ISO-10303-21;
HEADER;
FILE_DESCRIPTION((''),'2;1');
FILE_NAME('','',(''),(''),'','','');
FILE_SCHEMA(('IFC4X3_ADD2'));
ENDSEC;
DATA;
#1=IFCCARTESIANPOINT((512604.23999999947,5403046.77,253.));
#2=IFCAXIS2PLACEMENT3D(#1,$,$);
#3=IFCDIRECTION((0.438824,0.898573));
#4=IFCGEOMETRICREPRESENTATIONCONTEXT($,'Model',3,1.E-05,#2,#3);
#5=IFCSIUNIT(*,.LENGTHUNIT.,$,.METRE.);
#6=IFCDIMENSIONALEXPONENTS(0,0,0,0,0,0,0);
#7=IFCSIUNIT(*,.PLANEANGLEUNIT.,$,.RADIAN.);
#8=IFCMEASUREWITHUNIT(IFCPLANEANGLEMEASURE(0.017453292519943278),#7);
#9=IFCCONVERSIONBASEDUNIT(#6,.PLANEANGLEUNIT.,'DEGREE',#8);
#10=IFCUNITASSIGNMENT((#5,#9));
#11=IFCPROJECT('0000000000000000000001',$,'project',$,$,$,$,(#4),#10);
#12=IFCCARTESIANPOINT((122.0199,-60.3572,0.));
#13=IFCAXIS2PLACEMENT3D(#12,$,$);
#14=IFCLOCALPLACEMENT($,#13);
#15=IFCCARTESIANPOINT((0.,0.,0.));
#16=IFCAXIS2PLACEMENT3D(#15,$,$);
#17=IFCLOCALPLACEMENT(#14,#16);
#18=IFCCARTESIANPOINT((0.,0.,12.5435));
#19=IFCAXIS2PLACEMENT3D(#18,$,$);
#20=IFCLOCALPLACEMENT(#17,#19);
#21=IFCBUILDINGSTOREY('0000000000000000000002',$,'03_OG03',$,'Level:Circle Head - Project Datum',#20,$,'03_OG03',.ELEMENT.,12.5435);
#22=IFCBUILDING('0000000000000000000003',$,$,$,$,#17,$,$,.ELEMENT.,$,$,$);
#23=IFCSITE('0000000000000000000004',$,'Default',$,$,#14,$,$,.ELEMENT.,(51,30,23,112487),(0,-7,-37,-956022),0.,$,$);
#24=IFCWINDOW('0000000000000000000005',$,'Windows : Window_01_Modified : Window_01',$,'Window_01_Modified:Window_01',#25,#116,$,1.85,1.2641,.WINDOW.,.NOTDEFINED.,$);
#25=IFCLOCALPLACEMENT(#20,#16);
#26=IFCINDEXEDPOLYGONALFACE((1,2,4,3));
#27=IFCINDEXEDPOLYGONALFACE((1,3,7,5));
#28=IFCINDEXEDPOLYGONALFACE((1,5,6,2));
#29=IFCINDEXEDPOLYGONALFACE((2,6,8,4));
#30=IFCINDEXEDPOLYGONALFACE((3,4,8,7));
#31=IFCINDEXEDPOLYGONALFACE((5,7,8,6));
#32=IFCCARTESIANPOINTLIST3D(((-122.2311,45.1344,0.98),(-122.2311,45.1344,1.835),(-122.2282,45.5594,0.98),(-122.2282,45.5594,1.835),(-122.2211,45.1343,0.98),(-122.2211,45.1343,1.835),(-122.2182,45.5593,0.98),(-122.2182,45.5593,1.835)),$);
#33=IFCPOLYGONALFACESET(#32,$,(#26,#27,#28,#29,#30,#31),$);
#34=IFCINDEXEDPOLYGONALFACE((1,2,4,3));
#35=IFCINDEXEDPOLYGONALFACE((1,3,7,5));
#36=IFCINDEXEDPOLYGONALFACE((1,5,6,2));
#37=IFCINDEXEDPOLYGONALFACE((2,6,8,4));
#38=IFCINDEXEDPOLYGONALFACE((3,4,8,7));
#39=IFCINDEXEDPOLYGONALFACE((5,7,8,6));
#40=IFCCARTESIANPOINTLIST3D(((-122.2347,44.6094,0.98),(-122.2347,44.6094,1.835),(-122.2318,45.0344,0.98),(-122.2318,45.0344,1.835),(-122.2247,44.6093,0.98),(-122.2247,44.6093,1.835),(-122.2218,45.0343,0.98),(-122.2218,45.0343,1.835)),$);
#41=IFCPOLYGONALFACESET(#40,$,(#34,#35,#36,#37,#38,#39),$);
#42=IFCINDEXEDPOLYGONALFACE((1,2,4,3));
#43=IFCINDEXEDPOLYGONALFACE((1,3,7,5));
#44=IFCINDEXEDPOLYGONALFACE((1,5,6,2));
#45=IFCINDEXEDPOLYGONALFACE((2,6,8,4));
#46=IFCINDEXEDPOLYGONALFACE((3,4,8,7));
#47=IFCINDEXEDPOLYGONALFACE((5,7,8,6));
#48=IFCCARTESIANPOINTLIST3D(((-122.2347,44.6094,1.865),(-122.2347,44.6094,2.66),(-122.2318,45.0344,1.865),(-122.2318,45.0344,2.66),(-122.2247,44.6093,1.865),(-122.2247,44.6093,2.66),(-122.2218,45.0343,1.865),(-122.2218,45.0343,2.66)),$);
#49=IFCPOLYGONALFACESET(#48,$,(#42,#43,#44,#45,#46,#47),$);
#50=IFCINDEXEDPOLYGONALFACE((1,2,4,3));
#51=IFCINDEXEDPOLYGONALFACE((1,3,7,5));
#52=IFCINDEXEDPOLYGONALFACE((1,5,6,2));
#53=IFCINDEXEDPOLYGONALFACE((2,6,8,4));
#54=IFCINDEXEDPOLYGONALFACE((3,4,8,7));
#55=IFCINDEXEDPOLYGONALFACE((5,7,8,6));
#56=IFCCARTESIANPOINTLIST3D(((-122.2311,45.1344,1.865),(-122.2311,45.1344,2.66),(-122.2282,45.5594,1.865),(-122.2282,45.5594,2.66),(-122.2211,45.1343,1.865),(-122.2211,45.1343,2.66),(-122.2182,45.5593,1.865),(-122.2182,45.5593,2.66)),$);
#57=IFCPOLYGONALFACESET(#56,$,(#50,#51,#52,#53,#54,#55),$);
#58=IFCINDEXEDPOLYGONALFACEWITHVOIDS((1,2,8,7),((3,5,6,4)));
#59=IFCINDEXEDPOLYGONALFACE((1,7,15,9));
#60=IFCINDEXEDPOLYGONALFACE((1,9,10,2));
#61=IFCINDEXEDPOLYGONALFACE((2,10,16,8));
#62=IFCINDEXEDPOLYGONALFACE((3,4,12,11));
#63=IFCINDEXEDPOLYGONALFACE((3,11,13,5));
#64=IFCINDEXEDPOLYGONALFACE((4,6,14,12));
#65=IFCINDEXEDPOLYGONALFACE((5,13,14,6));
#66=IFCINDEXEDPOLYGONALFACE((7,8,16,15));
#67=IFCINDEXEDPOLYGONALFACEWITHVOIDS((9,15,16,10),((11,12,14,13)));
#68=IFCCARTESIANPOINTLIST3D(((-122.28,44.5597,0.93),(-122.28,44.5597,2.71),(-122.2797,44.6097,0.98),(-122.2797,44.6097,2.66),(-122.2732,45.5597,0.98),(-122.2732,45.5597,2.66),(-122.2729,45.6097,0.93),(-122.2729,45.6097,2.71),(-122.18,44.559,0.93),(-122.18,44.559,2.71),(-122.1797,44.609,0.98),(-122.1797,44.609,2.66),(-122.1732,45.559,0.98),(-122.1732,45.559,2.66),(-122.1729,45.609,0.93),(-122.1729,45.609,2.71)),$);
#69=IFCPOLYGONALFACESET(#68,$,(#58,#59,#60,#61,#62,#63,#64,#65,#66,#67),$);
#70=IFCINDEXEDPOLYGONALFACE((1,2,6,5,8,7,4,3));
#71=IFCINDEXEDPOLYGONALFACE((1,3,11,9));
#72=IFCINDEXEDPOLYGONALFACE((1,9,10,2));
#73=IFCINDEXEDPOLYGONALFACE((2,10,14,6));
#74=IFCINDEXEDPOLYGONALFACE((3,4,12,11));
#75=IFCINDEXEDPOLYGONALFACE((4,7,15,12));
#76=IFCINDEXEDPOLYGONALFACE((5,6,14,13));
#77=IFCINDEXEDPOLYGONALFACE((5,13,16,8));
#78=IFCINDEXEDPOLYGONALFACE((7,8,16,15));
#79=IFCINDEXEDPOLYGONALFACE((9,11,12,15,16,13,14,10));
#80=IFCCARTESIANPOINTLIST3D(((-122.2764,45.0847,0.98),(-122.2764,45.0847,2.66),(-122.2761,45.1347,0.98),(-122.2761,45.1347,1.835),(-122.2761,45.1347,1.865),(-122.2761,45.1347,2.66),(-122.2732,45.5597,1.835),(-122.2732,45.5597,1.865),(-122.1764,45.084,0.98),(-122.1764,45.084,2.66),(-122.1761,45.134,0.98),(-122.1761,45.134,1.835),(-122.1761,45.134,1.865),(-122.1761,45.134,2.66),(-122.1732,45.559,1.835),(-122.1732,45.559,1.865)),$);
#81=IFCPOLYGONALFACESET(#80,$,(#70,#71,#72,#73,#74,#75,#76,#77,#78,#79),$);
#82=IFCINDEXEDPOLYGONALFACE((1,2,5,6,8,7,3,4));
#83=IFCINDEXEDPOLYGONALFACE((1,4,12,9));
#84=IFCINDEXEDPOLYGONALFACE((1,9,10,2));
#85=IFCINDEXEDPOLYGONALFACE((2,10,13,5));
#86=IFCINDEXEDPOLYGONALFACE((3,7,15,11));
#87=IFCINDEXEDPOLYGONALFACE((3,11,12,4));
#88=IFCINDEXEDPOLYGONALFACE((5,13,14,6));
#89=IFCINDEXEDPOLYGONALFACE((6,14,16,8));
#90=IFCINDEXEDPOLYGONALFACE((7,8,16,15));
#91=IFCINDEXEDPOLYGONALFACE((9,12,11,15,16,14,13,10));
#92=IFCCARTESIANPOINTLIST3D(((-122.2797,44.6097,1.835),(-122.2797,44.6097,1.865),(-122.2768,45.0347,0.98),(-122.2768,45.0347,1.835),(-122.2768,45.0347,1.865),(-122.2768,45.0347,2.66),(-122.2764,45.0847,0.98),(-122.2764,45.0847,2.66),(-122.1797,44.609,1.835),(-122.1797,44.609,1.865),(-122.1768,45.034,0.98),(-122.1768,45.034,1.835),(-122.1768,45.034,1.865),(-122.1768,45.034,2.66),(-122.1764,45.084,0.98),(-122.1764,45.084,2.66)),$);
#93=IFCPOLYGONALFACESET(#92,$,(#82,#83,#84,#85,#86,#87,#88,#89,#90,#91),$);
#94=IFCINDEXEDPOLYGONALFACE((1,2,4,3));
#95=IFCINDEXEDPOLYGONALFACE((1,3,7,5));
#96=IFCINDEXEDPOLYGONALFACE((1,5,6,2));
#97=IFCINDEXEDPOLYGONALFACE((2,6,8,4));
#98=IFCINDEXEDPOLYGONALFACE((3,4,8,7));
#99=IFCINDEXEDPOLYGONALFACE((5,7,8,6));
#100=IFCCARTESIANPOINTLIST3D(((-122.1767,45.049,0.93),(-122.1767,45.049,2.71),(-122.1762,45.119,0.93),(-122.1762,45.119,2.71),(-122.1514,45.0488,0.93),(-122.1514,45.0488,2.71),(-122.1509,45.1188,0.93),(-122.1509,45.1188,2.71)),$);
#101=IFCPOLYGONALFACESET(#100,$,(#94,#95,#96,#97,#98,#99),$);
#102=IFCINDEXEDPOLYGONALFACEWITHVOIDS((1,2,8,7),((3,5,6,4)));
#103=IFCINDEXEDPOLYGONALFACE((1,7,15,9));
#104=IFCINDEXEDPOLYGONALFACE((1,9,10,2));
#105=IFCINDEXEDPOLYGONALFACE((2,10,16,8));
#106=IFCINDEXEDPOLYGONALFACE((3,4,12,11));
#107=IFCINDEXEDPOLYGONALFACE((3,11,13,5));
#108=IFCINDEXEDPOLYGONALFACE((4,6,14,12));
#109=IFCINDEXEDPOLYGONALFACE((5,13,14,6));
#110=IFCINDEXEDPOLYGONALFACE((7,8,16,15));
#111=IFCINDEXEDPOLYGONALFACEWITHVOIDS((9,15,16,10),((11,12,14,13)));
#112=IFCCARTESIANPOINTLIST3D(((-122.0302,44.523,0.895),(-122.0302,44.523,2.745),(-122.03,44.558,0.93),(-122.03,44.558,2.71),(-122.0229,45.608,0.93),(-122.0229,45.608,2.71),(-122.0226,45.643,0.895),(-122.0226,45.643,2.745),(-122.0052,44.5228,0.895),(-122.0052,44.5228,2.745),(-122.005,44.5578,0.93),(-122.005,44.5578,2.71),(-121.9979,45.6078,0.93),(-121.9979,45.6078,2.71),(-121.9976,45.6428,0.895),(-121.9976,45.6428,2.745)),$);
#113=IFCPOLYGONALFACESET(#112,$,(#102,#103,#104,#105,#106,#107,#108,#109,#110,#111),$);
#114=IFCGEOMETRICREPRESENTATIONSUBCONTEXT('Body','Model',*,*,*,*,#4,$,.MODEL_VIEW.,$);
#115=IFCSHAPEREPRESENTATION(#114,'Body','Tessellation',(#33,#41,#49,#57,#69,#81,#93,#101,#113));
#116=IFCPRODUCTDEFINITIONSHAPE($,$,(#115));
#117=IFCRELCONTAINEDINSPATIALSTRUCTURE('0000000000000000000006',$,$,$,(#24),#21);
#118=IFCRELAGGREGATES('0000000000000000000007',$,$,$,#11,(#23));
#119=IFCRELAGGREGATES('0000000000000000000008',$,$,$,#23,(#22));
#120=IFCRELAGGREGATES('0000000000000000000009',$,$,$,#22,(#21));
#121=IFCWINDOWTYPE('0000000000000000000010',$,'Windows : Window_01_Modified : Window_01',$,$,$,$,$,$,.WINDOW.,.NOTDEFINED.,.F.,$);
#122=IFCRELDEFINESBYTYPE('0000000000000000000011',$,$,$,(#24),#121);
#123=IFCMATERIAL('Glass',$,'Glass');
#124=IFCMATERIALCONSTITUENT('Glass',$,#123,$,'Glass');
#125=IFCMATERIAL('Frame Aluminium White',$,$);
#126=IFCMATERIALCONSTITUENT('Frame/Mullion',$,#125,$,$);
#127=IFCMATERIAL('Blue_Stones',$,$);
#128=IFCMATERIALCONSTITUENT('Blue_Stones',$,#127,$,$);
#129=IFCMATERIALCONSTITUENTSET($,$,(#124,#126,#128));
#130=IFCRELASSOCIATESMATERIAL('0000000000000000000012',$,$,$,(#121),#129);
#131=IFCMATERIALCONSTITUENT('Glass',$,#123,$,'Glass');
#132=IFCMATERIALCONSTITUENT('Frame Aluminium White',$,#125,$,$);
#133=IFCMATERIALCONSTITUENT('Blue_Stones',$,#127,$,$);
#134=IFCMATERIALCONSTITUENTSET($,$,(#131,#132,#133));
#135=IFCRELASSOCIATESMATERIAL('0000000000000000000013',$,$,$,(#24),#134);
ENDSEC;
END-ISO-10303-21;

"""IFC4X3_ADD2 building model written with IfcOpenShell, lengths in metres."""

from ifc_helpers import new_model, entity, si_unit, converted_unit, direction, frame, frame_2d, origin, place, context, subcontext, project, spatial, polyline, rectangle, outline, extrude, source, transform, mapped, material, constituent, constituent_set, type_object, type_shapes, element, save


model = new_model("IFC4X3_ADD2")

# Units and contexts
model_context = context("Model", 3, precision=1e-05, world=frame((512604.23999999947, 5403046.77, 253.0)), true_north=direction((0.438824, 0.898573)))
body_context = subcontext(model_context, "Body", "Model", "MODEL_VIEW")
ifc_project = project(units=[si_unit("LENGTHUNIT", "METRE"), converted_unit("PLANEANGLEUNIT", "DEGREE", entity("IfcPlaneAngleMeasure", 0.017453292519943278), si_unit("PLANEANGLEUNIT", "RADIAN"), dimensions=[0, 0, 0, 0, 0, 0, 0])], contexts=[model_context])

# Site, building, storey
site_placement = place(None, frame((122.0199, -60.3572, 0.0)))
site = spatial("IfcSite", under=ifc_project, at=site_placement, Name="Default", CompositionType="ELEMENT", RefLatitude=(51, 30, 23, 112487), RefLongitude=(0, -7, -37, -956022), RefElevation=0.0)
building_placement = place(site_placement, origin())
building = spatial("IfcBuilding", under=site, at=building_placement, CompositionType="ELEMENT")
storey_placement = place(building_placement, frame((0.0, 0.0, 12.5435)))
storey = spatial("IfcBuildingStorey", under=building, at=storey_placement, Name="03_OG03", ObjectType="Level:Circle Head - Project Datum", LongName="03_OG03", CompositionType="ELEMENT", Elevation=12.5435)

# Window
ifc_material_1 = material(Name="Glass", Category="Glass")
ifc_material_2 = material(Name="Frame Aluminium White")
ifc_material_3 = material(Name="Blue_Stones")
ifc_constituent_1 = constituent(ifc_material_1, Name="Glass", Category="Glass")
ifc_constituent_2 = constituent(ifc_material_2, Name="Frame Aluminium White")
ifc_constituent_3 = constituent(ifc_material_3, Name="Blue_Stones")
ifc_constituent_set_1 = constituent_set(constituents=[ifc_constituent_1, ifc_constituent_2, ifc_constituent_3])
ifc_constituent_4 = constituent(ifc_material_1, Name="Glass", Category="Glass")
ifc_constituent_5 = constituent(ifc_material_2, Name="Frame/Mullion")
ifc_constituent_6 = constituent(ifc_material_3, Name="Blue_Stones")
ifc_constituent_set_2 = constituent_set(constituents=[ifc_constituent_4, ifc_constituent_5, ifc_constituent_6])
window_type_1 = type_object("IfcWindowType", Name="Windows : Window_01_Modified : Window_01", ParameterTakesPrecedence=False, PartitioningType="NOTDEFINED", PredefinedType="WINDOW", material=ifc_constituent_set_2)
shared_shape_1 = source(origin(), body_context, "Body", "SweptSolid", [
    extrude(rectangle(XDim=0.425, YDim=0.01, at=frame_2d((0.0, 0.0), x_axis=(1.0, 0.0))), frame((0.4019, -0.2, 0.0514), z_axis=(0.0, 0.0, 1.0), x_axis=(-1.0, 0.0, 0.0)), (0.0, 0.0, 1.0), 0.855),
    extrude(rectangle(XDim=0.01, YDim=0.425, at=frame_2d((0.0, 0.0), x_axis=(1.0, 0.0))), frame((0.9269, -0.2, 0.0514), z_axis=(0.0, 0.0, 1.0), x_axis=(0.0, 1.0, 0.0)), (0.0, 0.0, 1.0), 0.855),
    extrude(rectangle(XDim=0.425, YDim=0.01, at=frame_2d((0.0, 0.0), x_axis=(1.0, 0.0))), frame((0.9269, -0.2, 0.9364), z_axis=(0.0, 0.0, 1.0), x_axis=(-1.0, 0.0, 0.0)), (0.0, 0.0, 1.0), 0.795),
    extrude(rectangle(XDim=0.425, YDim=0.01, at=frame_2d((0.0, 0.0), x_axis=(1.0, 0.0))), frame((0.4019, -0.2, 0.9364), z_axis=(0.0, 0.0, 1.0), x_axis=(-1.0, 0.0, 0.0)), (0.0, 0.0, 1.0), 0.795),
    extrude(outline(polyline([(-0.89, -0.525), (0.89, -0.525), (0.89, 0.525), (-0.89, 0.525), (-0.89, -0.525)]), holes=[polyline([(0.84, 0.475), (0.84, -0.475), (-0.84, -0.475), (-0.84, 0.475), (0.84, 0.475)])]), frame((0.6644, -0.25, 0.8914), z_axis=(0.0, 1.0, 0.0), x_axis=(0.0, 0.0, 1.0)), (0.0, 0.0, 1.0), 0.1),
    extrude(outline(polyline([(0.03, 0.0937), (0.825, 0.0937), (0.825, 0.1438), (-0.855, 0.1438), (-0.855, 0.0937), (0.0, 0.0937), (0.0, -0.3312), (0.03, -0.3312), (0.03, 0.0937)])), frame((0.5206, -0.25, 0.9064), z_axis=(0.0, 1.0, 0.0), x_axis=(0.0, 0.0, 1.0)), (0.0, 0.0, 1.0), 0.1),
    extrude(outline(polyline([(-0.825, -0.0938), (-0.825, -0.1437), (0.855, -0.1437), (0.855, -0.0938), (0.0, -0.0938), (0.0, 0.3313), (-0.03, 0.3313), (-0.03, -0.0938), (-0.825, -0.0938)])), frame((0.8081, -0.25, 0.9064), z_axis=(0.0, -1.0, 0.0), x_axis=(0.0, 0.0, -1.0)), (0.0, 0.0, -1.0), 0.1),
    extrude(rectangle(XDim=0.0253, YDim=0.07, at=frame_2d((0.0, 0.0), x_axis=(1.0, 0.0))), frame((0.6644, -0.1374, 0.0014), z_axis=(0.0, 0.0, 1.0), x_axis=(0.0, -1.0, 0.0)), (0.0, 0.0, 1.0), 1.78),
    extrude(outline(polyline([(-0.56, -0.925), (0.56, -0.925), (0.56, 0.925), (-0.56, 0.925), (-0.56, -0.925)]), holes=[polyline([(-0.525, -0.89), (-0.525, 0.89), (0.525, 0.89), (0.525, -0.89), (-0.525, -0.89)])]), frame((0.6644, 0.0, 0.8914), z_axis=(0.0, 1.0, 0.0), x_axis=(1.0, 0.0, 0.0)), (0.0, 0.0, 1.0), 0.025),
])
type_shapes(window_type_1, [shared_shape_1])
window_1_placement = place(storey_placement, frame((-122.0219, 45.7473, 0.9286), z_axis=(0.0, 0.0, 1.0), x_axis=(-0.0068, -0.999977, 0.0)))
element("IfcWindow", 1, at=window_1_placement, inside=storey, type_object=window_type_1, material=ifc_constituent_set_1, Name="Windows : Window_01_Modified : Window_01", ObjectType="Window_01_Modified:Window_01", OverallHeight=1.85, OverallWidth=1.2641, PartitioningType="NOTDEFINED", PredefinedType="WINDOW", context=body_context, shape_type="MappedRepresentation", body=[
    mapped(shared_shape_1, transform((0.0, 0.0, 0.0), scale=1.0)),
])

save(model, "model.ifc")
